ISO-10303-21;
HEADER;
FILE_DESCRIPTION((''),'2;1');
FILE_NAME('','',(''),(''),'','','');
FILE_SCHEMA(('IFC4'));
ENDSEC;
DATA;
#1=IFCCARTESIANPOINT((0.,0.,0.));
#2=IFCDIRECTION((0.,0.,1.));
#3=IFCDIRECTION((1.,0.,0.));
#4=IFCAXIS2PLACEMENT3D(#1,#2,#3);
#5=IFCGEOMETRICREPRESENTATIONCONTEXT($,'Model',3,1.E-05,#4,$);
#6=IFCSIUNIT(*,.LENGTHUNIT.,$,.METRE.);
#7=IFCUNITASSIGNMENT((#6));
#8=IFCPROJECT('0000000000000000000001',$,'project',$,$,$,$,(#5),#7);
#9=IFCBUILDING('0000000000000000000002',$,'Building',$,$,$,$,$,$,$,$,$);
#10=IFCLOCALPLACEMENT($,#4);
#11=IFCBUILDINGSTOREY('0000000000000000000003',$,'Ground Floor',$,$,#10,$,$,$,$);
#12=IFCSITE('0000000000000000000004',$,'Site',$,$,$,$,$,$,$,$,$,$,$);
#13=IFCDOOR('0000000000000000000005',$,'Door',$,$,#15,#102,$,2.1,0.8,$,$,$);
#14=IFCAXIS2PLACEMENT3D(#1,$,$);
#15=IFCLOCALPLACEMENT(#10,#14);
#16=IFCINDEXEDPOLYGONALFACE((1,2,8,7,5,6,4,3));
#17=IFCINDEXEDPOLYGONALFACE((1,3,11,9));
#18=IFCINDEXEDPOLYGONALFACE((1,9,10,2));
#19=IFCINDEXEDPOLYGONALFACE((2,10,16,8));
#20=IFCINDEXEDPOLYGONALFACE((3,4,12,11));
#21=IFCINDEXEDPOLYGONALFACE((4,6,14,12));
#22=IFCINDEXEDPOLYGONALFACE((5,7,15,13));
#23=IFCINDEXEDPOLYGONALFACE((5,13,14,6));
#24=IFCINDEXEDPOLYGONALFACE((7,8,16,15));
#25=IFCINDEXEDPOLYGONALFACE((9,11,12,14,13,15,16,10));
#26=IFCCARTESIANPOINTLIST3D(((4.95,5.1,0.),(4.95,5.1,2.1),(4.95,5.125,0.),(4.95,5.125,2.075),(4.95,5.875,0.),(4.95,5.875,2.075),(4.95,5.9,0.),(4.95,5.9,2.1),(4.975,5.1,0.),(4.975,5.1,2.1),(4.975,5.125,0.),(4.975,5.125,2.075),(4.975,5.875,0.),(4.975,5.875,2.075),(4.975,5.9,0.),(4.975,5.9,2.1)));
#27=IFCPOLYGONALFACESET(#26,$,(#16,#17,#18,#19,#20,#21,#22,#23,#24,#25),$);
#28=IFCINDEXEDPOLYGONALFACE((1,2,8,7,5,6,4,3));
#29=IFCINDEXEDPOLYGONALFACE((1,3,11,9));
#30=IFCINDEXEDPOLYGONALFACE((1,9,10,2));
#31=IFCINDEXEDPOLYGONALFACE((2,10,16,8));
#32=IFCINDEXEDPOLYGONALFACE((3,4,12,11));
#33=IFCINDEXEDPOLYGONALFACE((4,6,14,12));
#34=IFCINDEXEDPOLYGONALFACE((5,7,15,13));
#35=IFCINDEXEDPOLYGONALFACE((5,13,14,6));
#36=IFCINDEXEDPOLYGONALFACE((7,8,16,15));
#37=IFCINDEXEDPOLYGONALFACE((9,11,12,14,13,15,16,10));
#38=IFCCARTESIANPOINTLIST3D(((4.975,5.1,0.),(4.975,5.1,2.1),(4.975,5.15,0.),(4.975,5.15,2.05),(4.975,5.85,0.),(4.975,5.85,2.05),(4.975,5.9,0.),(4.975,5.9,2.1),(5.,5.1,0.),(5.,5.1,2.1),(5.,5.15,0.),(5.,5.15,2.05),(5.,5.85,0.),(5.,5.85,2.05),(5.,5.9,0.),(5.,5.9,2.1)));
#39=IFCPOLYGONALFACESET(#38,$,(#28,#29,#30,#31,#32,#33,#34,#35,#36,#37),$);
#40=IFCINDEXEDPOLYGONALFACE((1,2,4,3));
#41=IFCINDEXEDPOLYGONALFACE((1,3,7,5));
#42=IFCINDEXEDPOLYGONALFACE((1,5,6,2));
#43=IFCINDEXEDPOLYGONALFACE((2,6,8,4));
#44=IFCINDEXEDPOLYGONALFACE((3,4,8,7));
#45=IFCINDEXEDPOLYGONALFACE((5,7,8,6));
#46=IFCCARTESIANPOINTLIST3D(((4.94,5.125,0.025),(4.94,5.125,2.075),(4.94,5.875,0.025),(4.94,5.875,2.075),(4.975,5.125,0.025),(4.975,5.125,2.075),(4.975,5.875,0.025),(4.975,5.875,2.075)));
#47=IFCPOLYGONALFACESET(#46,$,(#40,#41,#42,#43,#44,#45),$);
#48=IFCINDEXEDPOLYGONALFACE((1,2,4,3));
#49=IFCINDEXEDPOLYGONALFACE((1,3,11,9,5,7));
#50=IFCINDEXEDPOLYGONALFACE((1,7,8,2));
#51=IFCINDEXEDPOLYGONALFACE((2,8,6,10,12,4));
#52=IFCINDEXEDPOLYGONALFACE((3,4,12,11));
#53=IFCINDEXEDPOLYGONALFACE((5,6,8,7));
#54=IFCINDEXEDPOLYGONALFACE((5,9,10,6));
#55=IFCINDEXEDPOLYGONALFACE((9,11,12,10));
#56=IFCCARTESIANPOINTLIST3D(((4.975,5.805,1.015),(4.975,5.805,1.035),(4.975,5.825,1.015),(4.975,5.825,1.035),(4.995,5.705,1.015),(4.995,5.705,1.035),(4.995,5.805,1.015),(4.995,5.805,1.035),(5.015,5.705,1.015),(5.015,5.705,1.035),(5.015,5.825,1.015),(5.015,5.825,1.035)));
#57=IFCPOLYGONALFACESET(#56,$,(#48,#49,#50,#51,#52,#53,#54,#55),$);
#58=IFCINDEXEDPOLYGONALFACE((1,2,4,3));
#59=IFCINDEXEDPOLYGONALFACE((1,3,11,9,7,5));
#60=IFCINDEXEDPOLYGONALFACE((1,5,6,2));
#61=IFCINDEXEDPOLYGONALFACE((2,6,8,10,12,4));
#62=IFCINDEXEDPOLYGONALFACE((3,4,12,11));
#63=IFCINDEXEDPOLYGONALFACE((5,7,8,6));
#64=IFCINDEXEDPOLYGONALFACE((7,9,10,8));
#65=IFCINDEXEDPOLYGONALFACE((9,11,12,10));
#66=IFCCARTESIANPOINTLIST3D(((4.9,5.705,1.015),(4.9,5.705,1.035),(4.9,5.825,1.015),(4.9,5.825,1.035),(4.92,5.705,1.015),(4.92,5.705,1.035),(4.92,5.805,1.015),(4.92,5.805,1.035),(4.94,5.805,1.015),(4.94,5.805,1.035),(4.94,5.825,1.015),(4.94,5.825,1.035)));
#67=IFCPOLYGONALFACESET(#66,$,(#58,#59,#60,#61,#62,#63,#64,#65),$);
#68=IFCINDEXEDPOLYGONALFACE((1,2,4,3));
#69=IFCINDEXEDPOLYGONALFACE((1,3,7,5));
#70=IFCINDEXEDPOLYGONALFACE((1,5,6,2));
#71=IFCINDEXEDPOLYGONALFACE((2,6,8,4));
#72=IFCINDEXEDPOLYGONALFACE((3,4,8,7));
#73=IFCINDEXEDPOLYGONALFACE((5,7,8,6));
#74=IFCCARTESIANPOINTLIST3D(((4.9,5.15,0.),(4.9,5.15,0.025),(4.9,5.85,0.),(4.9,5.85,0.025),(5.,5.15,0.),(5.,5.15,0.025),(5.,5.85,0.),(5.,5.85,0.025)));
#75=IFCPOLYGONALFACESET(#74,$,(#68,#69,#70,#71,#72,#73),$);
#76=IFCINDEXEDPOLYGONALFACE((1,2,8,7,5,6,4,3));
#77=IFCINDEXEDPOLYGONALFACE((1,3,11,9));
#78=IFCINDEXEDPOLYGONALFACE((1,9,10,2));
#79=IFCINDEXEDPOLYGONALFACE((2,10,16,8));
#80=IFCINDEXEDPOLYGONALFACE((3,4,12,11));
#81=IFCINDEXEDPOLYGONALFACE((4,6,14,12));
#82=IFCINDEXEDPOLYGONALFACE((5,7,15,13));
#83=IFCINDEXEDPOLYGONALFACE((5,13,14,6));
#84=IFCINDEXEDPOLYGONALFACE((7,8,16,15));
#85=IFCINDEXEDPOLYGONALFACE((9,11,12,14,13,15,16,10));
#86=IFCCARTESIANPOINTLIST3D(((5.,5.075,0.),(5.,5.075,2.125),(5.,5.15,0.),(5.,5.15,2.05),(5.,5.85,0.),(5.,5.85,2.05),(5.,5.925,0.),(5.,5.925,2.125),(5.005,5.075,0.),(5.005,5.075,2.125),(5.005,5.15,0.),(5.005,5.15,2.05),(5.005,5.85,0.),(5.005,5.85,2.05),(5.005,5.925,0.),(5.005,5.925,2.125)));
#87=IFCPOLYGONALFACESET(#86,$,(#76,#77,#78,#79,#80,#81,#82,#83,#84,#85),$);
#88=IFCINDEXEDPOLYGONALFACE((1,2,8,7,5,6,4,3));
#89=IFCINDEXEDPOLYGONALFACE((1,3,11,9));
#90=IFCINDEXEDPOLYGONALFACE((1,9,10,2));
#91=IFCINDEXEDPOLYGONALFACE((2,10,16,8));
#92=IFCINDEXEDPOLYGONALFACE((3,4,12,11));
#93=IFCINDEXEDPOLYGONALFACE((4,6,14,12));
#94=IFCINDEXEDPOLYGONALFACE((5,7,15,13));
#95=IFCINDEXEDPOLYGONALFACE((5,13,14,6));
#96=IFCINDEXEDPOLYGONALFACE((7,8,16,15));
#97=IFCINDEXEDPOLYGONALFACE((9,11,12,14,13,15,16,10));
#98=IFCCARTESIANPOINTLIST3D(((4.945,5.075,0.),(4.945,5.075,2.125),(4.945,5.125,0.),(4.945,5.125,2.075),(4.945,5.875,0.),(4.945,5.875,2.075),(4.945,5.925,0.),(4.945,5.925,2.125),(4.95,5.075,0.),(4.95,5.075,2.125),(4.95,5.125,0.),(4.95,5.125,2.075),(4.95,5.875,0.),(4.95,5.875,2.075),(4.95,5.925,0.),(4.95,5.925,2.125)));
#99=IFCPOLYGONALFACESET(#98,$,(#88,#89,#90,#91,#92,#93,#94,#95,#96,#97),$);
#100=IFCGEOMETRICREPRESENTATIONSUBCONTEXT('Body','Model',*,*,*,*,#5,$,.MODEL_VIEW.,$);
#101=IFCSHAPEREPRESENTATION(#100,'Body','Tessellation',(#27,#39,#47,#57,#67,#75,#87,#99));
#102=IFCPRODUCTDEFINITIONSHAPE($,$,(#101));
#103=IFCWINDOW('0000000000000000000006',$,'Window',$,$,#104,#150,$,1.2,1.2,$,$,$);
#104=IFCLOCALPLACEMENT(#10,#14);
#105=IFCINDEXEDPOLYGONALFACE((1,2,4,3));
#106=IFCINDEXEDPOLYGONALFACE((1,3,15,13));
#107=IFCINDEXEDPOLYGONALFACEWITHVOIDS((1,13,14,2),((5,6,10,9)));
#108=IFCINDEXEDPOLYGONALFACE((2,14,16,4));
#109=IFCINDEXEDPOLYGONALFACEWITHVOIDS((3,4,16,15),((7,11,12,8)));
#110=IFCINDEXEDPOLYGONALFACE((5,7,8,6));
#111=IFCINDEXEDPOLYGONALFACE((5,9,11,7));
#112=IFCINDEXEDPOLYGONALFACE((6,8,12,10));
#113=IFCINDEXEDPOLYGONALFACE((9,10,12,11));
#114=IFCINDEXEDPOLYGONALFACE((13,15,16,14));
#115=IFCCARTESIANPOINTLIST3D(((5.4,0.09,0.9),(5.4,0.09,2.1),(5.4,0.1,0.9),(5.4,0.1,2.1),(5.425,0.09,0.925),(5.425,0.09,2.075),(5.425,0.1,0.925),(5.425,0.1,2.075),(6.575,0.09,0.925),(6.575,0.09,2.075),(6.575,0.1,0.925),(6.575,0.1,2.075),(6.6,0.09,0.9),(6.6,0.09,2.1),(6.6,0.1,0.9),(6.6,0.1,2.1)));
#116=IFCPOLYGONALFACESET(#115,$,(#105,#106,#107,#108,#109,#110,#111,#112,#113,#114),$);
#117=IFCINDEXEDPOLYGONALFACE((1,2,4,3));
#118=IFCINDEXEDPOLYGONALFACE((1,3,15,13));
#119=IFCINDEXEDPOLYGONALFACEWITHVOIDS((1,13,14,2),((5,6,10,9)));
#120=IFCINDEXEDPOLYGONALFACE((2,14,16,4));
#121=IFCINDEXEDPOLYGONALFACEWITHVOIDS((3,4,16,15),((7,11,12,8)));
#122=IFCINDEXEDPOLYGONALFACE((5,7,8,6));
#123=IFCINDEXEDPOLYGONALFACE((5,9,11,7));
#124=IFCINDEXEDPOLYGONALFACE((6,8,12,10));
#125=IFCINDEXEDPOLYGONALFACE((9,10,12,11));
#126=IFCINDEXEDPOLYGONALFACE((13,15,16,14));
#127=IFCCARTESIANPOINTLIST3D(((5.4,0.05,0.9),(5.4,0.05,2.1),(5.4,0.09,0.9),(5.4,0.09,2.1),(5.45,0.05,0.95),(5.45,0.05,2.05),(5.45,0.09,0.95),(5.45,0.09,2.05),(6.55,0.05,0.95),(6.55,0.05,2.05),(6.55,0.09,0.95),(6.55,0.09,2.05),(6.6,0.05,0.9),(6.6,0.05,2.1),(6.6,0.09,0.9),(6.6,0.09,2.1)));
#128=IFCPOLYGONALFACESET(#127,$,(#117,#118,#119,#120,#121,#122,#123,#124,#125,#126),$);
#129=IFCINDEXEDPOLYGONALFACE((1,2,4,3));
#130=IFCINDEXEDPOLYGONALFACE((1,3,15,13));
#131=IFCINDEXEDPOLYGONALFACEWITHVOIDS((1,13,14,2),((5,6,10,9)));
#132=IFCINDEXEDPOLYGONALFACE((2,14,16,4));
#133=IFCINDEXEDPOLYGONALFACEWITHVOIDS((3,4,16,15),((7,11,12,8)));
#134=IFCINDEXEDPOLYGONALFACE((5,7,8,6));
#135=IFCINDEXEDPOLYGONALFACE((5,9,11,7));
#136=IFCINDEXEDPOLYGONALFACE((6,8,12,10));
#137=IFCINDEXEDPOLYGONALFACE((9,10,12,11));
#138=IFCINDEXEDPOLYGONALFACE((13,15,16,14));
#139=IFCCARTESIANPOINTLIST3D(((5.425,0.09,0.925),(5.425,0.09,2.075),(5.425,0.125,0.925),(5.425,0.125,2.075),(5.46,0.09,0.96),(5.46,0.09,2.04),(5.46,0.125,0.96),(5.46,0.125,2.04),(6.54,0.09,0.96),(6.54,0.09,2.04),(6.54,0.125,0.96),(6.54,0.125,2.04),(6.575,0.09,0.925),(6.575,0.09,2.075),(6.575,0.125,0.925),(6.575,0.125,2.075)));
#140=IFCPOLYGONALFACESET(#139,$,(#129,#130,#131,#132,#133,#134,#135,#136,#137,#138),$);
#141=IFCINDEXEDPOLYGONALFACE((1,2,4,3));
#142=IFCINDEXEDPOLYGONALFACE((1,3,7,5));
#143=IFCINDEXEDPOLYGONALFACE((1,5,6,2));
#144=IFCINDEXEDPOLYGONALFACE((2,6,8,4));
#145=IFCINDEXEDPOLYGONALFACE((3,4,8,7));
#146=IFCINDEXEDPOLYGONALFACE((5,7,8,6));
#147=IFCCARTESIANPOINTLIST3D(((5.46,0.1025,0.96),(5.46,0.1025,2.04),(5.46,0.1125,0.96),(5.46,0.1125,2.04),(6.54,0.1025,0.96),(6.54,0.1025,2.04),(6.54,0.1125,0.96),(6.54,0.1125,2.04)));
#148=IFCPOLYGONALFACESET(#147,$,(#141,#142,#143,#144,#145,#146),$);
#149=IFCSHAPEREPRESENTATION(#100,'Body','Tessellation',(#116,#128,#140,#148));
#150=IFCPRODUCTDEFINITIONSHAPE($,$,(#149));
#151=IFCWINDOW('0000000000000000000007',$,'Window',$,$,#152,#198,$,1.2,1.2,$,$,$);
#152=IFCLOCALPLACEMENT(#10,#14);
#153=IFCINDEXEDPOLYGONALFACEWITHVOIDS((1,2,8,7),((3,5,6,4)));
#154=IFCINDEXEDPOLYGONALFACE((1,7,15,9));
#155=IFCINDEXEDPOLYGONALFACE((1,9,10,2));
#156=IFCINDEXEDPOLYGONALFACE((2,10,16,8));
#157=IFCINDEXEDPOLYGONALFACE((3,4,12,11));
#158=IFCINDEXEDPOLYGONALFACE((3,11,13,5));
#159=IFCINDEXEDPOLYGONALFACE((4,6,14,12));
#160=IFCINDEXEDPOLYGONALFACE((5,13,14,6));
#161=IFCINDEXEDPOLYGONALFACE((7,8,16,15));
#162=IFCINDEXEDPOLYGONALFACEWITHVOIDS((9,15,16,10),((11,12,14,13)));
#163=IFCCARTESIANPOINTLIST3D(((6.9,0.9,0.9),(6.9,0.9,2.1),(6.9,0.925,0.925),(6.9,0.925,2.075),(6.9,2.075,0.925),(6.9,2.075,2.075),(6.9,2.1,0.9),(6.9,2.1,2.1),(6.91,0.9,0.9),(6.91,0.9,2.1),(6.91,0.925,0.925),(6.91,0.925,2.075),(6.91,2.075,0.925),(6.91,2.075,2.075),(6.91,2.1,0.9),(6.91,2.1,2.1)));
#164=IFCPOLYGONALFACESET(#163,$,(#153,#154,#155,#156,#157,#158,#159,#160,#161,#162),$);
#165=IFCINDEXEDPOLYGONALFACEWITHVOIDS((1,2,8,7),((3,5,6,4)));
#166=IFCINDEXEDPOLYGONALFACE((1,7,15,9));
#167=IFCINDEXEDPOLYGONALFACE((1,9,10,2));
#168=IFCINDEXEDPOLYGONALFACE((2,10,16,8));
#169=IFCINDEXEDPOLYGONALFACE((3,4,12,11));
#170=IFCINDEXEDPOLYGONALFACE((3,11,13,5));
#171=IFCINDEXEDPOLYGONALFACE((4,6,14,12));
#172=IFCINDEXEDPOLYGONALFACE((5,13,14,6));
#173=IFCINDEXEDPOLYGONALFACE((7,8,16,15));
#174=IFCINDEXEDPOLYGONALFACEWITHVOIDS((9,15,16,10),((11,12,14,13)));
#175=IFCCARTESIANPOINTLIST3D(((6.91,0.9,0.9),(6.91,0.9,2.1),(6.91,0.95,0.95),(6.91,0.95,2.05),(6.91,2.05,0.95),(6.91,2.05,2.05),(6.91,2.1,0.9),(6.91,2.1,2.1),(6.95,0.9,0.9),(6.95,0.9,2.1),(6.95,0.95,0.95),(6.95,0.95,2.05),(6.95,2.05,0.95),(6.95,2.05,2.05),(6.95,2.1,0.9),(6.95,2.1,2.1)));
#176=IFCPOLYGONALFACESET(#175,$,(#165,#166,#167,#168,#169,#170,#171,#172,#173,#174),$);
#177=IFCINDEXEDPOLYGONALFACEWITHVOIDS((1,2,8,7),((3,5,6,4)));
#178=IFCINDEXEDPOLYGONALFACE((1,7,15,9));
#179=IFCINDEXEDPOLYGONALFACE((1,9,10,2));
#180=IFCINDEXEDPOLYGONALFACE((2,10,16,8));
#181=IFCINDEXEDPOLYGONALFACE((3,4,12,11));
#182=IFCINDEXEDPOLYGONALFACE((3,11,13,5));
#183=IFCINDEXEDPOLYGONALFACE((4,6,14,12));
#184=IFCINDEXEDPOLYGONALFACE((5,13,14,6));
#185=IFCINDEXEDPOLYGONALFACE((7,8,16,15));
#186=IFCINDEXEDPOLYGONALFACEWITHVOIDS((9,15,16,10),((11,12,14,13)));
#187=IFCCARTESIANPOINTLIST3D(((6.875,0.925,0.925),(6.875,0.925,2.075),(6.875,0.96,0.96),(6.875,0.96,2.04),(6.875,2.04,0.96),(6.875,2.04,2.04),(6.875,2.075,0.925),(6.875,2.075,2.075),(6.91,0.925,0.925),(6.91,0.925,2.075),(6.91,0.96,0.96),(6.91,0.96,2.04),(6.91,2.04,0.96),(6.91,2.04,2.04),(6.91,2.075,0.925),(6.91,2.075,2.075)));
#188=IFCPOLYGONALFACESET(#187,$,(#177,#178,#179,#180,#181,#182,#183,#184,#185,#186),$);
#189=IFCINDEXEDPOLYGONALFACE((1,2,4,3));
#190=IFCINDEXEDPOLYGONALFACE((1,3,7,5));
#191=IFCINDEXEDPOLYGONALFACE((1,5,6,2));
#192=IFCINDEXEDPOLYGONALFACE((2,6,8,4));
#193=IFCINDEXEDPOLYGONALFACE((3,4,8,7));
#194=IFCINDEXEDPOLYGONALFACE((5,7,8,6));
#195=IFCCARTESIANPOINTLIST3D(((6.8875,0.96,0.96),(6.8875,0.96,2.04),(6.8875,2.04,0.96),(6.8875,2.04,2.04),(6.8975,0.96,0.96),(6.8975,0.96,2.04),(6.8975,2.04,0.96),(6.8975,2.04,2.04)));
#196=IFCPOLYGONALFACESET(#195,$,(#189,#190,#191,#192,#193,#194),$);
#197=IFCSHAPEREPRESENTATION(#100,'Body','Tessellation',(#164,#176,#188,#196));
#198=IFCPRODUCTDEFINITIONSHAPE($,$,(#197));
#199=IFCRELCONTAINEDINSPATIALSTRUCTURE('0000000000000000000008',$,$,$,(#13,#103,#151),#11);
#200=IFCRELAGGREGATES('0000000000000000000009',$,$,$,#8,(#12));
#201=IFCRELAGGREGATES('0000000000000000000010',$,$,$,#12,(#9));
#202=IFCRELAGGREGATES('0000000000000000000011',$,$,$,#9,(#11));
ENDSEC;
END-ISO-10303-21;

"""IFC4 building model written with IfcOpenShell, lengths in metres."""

from ifc_helpers import new_model, si_unit, frame, origin_with_axes, place, context, subcontext, project, spatial, line, indexed_curve, outline, extrude, element, save


model = new_model("IFC4")

# Units and contexts
model_context = context("Model", 3, precision=1e-05, world=origin_with_axes())
body_context = subcontext(model_context, "Body", "Model", "MODEL_VIEW")
ifc_project = project(units=[si_unit("LENGTHUNIT", "METRE")], contexts=[model_context])

# Site, building, storey
site = spatial("IfcSite", under=ifc_project, Name="Site")
building = spatial("IfcBuilding", under=site, Name="Building")
storey_placement = place(None, origin_with_axes())
storey = spatial("IfcBuildingStorey", under=building, at=storey_placement, Name="Ground Floor")

# Door
door_1_placement = place(storey_placement, frame((5.0, 5.1, 0.0), z_axis=(0.0, 0.0, 1.0), x_axis=(0.0, 1.0, 0.0)))
element("IfcDoor", 1, at=door_1_placement, inside=storey, Name="Door", OverallHeight=2.1, OverallWidth=0.8, context=body_context, shape_type="SweptSolid", body=[
    extrude(outline(indexed_curve([(0.0, 0.0), (0.0, 2.1), (0.8, 2.1), (0.8, 0.0), (0.775, 0.0), (0.775, 2.075), (0.025, 2.075), (0.025, 0.0)], segments=[line(1, 2, 3, 4, 5, 6, 7, 8, 1)])), frame((0.0, 0.025, 0.0), z_axis=(0.0, -1.0, 0.0), x_axis=(1.0, 0.0, 0.0)), (0.0, 0.0, -1.0), 0.025),
    extrude(outline(indexed_curve([(0.0, 0.0), (0.0, 2.1), (0.8, 2.1), (0.8, 0.0), (0.75, 0.0), (0.75, 2.05), (0.05, 2.05), (0.05, 0.0)], segments=[line(1, 2, 3, 4, 5, 6, 7, 8, 1)])), frame((0.0, 0.0, 0.0), z_axis=(0.0, -1.0, 0.0), x_axis=(1.0, 0.0, 0.0)), (0.0, 0.0, -1.0), 0.025),
    extrude(outline(indexed_curve([(0.0, 0.0), (0.75, 0.0), (0.75, 0.035), (0.0, 0.035)], segments=[line(1, 2, 3, 4, 1)])), frame((0.025, 0.025, 0.025), z_axis=(0.0, 0.0, 1.0), x_axis=(1.0, 0.0, 0.0)), (0.0, 0.0, 1.0), 2.05),
    extrude(outline(indexed_curve([(0.0, 0.0), (0.0, -0.04), (-0.12, -0.04), (-0.12, -0.02), (-0.02, -0.02), (-0.02, 0.0)], segments=[line(1, 2, 3, 4, 5, 6, 1)])), frame((0.725, 0.025, 1.015), z_axis=(0.0, 0.0, 1.0), x_axis=(1.0, 0.0, 0.0)), (0.0, 0.0, 1.0), 0.02),
    extrude(outline(indexed_curve([(0.0, 0.0), (0.0, 0.04), (-0.12, 0.04), (-0.12, 0.02), (-0.02, 0.02), (-0.02, 0.0)], segments=[line(1, 2, 3, 4, 5, 6, 1)])), frame((0.725, 0.06, 1.015), z_axis=(0.0, 0.0, 1.0), x_axis=(1.0, 0.0, 0.0)), (0.0, 0.0, 1.0), 0.02),
    extrude(outline(indexed_curve([(0.0, 0.0), (0.7, 0.0), (0.7, 0.1), (0.0, 0.1)], segments=[line(1, 2, 3, 4, 1)])), frame((0.05, 0.0, 0.0), z_axis=(0.0, 0.0, 1.0), x_axis=(1.0, 0.0, 0.0)), (0.0, 0.0, 1.0), 0.025),
    extrude(outline(indexed_curve([(0.0, 0.0), (0.0, 2.125), (0.85, 2.125), (0.85, 0.0), (0.775, 0.0), (0.775, 2.05), (0.075, 2.05), (0.075, 0.0)], segments=[line(1, 2, 3, 4, 5, 6, 7, 8, 1)])), frame((-0.025, -0.005, 0.0), z_axis=(0.0, -1.0, 0.0), x_axis=(1.0, 0.0, 0.0)), (0.0, 0.0, -1.0), 0.005),
    extrude(outline(indexed_curve([(0.0, 0.0), (0.0, 2.125), (0.85, 2.125), (0.85, 0.0), (0.8, 0.0), (0.8, 2.075), (0.05, 2.075), (0.05, 0.0)], segments=[line(1, 2, 3, 4, 5, 6, 7, 8, 1)])), frame((-0.025, 0.05, 0.0), z_axis=(0.0, -1.0, 0.0), x_axis=(1.0, 0.0, 0.0)), (0.0, 0.0, -1.0), 0.005),
])

# Windows
for number, where, z_axis, x_axis, name in (
    (2, (5.4, 0.0, 0.9), (0.0, 0.0, 1.0), (1.0, 0.0, 0.0), "Window"),
    (3, (7.0, 0.9, 0.9), (0.0, 0.0, 1.0), (0.0, 1.0, 0.0), "Window"),
):
    element("IfcWindow", number, at=place(storey_placement, frame(where, z_axis=z_axis, x_axis=x_axis)), inside=storey, Name=name, OverallHeight=1.2, OverallWidth=1.2, context=body_context, shape_type="SweptSolid", body=[
        extrude(outline(indexed_curve([(0.0, 0.0), (1.2, 0.0), (1.2, 1.2), (0.0, 1.2)], segments=[line(1, 2, 3, 4, 1)]), holes=[indexed_curve([(0.025, 0.025), (1.175, 0.025), (1.175, 1.175), (0.025, 1.175)], segments=[line(1, 2, 3, 4, 1)])]), frame((0.0, 0.09, 0.0), z_axis=(0.0, -1.0, 0.0), x_axis=(1.0, 0.0, 0.0)), (0.0, 0.0, -1.0), 0.01),
        extrude(outline(indexed_curve([(0.0, 0.0), (1.2, 0.0), (1.2, 1.2), (0.0, 1.2)], segments=[line(1, 2, 3, 4, 1)]), holes=[indexed_curve([(0.05, 0.05), (1.15, 0.05), (1.15, 1.15), (0.05, 1.15)], segments=[line(1, 2, 3, 4, 1)])]), frame((0.0, 0.05, 0.0), z_axis=(0.0, -1.0, 0.0), x_axis=(1.0, 0.0, 0.0)), (0.0, 0.0, -1.0), 0.04),
        extrude(outline(indexed_curve([(0.0, 0.0), (1.15, 0.0), (1.15, 1.15), (0.0, 1.15)], segments=[line(1, 2, 3, 4, 1)]), holes=[indexed_curve([(0.035, 0.035), (1.115, 0.035), (1.115, 1.115), (0.035, 1.115)], segments=[line(1, 2, 3, 4, 1)])]), frame((0.025, 0.09, 0.025), z_axis=(0.0, -1.0, 0.0), x_axis=(1.0, 0.0, 0.0)), (0.0, 0.0, -1.0), 0.035),
        extrude(outline(indexed_curve([(0.035, 0.035), (1.115, 0.035), (1.115, 1.115), (0.035, 1.115)], segments=[line(1, 2, 3, 4, 1)])), frame((0.025, 0.1025, 0.025), z_axis=(0.0, -1.0, 0.0), x_axis=(1.0, 0.0, 0.0)), (0.0, 0.0, -1.0), 0.01),
    ])

save(model, "model.ifc")
